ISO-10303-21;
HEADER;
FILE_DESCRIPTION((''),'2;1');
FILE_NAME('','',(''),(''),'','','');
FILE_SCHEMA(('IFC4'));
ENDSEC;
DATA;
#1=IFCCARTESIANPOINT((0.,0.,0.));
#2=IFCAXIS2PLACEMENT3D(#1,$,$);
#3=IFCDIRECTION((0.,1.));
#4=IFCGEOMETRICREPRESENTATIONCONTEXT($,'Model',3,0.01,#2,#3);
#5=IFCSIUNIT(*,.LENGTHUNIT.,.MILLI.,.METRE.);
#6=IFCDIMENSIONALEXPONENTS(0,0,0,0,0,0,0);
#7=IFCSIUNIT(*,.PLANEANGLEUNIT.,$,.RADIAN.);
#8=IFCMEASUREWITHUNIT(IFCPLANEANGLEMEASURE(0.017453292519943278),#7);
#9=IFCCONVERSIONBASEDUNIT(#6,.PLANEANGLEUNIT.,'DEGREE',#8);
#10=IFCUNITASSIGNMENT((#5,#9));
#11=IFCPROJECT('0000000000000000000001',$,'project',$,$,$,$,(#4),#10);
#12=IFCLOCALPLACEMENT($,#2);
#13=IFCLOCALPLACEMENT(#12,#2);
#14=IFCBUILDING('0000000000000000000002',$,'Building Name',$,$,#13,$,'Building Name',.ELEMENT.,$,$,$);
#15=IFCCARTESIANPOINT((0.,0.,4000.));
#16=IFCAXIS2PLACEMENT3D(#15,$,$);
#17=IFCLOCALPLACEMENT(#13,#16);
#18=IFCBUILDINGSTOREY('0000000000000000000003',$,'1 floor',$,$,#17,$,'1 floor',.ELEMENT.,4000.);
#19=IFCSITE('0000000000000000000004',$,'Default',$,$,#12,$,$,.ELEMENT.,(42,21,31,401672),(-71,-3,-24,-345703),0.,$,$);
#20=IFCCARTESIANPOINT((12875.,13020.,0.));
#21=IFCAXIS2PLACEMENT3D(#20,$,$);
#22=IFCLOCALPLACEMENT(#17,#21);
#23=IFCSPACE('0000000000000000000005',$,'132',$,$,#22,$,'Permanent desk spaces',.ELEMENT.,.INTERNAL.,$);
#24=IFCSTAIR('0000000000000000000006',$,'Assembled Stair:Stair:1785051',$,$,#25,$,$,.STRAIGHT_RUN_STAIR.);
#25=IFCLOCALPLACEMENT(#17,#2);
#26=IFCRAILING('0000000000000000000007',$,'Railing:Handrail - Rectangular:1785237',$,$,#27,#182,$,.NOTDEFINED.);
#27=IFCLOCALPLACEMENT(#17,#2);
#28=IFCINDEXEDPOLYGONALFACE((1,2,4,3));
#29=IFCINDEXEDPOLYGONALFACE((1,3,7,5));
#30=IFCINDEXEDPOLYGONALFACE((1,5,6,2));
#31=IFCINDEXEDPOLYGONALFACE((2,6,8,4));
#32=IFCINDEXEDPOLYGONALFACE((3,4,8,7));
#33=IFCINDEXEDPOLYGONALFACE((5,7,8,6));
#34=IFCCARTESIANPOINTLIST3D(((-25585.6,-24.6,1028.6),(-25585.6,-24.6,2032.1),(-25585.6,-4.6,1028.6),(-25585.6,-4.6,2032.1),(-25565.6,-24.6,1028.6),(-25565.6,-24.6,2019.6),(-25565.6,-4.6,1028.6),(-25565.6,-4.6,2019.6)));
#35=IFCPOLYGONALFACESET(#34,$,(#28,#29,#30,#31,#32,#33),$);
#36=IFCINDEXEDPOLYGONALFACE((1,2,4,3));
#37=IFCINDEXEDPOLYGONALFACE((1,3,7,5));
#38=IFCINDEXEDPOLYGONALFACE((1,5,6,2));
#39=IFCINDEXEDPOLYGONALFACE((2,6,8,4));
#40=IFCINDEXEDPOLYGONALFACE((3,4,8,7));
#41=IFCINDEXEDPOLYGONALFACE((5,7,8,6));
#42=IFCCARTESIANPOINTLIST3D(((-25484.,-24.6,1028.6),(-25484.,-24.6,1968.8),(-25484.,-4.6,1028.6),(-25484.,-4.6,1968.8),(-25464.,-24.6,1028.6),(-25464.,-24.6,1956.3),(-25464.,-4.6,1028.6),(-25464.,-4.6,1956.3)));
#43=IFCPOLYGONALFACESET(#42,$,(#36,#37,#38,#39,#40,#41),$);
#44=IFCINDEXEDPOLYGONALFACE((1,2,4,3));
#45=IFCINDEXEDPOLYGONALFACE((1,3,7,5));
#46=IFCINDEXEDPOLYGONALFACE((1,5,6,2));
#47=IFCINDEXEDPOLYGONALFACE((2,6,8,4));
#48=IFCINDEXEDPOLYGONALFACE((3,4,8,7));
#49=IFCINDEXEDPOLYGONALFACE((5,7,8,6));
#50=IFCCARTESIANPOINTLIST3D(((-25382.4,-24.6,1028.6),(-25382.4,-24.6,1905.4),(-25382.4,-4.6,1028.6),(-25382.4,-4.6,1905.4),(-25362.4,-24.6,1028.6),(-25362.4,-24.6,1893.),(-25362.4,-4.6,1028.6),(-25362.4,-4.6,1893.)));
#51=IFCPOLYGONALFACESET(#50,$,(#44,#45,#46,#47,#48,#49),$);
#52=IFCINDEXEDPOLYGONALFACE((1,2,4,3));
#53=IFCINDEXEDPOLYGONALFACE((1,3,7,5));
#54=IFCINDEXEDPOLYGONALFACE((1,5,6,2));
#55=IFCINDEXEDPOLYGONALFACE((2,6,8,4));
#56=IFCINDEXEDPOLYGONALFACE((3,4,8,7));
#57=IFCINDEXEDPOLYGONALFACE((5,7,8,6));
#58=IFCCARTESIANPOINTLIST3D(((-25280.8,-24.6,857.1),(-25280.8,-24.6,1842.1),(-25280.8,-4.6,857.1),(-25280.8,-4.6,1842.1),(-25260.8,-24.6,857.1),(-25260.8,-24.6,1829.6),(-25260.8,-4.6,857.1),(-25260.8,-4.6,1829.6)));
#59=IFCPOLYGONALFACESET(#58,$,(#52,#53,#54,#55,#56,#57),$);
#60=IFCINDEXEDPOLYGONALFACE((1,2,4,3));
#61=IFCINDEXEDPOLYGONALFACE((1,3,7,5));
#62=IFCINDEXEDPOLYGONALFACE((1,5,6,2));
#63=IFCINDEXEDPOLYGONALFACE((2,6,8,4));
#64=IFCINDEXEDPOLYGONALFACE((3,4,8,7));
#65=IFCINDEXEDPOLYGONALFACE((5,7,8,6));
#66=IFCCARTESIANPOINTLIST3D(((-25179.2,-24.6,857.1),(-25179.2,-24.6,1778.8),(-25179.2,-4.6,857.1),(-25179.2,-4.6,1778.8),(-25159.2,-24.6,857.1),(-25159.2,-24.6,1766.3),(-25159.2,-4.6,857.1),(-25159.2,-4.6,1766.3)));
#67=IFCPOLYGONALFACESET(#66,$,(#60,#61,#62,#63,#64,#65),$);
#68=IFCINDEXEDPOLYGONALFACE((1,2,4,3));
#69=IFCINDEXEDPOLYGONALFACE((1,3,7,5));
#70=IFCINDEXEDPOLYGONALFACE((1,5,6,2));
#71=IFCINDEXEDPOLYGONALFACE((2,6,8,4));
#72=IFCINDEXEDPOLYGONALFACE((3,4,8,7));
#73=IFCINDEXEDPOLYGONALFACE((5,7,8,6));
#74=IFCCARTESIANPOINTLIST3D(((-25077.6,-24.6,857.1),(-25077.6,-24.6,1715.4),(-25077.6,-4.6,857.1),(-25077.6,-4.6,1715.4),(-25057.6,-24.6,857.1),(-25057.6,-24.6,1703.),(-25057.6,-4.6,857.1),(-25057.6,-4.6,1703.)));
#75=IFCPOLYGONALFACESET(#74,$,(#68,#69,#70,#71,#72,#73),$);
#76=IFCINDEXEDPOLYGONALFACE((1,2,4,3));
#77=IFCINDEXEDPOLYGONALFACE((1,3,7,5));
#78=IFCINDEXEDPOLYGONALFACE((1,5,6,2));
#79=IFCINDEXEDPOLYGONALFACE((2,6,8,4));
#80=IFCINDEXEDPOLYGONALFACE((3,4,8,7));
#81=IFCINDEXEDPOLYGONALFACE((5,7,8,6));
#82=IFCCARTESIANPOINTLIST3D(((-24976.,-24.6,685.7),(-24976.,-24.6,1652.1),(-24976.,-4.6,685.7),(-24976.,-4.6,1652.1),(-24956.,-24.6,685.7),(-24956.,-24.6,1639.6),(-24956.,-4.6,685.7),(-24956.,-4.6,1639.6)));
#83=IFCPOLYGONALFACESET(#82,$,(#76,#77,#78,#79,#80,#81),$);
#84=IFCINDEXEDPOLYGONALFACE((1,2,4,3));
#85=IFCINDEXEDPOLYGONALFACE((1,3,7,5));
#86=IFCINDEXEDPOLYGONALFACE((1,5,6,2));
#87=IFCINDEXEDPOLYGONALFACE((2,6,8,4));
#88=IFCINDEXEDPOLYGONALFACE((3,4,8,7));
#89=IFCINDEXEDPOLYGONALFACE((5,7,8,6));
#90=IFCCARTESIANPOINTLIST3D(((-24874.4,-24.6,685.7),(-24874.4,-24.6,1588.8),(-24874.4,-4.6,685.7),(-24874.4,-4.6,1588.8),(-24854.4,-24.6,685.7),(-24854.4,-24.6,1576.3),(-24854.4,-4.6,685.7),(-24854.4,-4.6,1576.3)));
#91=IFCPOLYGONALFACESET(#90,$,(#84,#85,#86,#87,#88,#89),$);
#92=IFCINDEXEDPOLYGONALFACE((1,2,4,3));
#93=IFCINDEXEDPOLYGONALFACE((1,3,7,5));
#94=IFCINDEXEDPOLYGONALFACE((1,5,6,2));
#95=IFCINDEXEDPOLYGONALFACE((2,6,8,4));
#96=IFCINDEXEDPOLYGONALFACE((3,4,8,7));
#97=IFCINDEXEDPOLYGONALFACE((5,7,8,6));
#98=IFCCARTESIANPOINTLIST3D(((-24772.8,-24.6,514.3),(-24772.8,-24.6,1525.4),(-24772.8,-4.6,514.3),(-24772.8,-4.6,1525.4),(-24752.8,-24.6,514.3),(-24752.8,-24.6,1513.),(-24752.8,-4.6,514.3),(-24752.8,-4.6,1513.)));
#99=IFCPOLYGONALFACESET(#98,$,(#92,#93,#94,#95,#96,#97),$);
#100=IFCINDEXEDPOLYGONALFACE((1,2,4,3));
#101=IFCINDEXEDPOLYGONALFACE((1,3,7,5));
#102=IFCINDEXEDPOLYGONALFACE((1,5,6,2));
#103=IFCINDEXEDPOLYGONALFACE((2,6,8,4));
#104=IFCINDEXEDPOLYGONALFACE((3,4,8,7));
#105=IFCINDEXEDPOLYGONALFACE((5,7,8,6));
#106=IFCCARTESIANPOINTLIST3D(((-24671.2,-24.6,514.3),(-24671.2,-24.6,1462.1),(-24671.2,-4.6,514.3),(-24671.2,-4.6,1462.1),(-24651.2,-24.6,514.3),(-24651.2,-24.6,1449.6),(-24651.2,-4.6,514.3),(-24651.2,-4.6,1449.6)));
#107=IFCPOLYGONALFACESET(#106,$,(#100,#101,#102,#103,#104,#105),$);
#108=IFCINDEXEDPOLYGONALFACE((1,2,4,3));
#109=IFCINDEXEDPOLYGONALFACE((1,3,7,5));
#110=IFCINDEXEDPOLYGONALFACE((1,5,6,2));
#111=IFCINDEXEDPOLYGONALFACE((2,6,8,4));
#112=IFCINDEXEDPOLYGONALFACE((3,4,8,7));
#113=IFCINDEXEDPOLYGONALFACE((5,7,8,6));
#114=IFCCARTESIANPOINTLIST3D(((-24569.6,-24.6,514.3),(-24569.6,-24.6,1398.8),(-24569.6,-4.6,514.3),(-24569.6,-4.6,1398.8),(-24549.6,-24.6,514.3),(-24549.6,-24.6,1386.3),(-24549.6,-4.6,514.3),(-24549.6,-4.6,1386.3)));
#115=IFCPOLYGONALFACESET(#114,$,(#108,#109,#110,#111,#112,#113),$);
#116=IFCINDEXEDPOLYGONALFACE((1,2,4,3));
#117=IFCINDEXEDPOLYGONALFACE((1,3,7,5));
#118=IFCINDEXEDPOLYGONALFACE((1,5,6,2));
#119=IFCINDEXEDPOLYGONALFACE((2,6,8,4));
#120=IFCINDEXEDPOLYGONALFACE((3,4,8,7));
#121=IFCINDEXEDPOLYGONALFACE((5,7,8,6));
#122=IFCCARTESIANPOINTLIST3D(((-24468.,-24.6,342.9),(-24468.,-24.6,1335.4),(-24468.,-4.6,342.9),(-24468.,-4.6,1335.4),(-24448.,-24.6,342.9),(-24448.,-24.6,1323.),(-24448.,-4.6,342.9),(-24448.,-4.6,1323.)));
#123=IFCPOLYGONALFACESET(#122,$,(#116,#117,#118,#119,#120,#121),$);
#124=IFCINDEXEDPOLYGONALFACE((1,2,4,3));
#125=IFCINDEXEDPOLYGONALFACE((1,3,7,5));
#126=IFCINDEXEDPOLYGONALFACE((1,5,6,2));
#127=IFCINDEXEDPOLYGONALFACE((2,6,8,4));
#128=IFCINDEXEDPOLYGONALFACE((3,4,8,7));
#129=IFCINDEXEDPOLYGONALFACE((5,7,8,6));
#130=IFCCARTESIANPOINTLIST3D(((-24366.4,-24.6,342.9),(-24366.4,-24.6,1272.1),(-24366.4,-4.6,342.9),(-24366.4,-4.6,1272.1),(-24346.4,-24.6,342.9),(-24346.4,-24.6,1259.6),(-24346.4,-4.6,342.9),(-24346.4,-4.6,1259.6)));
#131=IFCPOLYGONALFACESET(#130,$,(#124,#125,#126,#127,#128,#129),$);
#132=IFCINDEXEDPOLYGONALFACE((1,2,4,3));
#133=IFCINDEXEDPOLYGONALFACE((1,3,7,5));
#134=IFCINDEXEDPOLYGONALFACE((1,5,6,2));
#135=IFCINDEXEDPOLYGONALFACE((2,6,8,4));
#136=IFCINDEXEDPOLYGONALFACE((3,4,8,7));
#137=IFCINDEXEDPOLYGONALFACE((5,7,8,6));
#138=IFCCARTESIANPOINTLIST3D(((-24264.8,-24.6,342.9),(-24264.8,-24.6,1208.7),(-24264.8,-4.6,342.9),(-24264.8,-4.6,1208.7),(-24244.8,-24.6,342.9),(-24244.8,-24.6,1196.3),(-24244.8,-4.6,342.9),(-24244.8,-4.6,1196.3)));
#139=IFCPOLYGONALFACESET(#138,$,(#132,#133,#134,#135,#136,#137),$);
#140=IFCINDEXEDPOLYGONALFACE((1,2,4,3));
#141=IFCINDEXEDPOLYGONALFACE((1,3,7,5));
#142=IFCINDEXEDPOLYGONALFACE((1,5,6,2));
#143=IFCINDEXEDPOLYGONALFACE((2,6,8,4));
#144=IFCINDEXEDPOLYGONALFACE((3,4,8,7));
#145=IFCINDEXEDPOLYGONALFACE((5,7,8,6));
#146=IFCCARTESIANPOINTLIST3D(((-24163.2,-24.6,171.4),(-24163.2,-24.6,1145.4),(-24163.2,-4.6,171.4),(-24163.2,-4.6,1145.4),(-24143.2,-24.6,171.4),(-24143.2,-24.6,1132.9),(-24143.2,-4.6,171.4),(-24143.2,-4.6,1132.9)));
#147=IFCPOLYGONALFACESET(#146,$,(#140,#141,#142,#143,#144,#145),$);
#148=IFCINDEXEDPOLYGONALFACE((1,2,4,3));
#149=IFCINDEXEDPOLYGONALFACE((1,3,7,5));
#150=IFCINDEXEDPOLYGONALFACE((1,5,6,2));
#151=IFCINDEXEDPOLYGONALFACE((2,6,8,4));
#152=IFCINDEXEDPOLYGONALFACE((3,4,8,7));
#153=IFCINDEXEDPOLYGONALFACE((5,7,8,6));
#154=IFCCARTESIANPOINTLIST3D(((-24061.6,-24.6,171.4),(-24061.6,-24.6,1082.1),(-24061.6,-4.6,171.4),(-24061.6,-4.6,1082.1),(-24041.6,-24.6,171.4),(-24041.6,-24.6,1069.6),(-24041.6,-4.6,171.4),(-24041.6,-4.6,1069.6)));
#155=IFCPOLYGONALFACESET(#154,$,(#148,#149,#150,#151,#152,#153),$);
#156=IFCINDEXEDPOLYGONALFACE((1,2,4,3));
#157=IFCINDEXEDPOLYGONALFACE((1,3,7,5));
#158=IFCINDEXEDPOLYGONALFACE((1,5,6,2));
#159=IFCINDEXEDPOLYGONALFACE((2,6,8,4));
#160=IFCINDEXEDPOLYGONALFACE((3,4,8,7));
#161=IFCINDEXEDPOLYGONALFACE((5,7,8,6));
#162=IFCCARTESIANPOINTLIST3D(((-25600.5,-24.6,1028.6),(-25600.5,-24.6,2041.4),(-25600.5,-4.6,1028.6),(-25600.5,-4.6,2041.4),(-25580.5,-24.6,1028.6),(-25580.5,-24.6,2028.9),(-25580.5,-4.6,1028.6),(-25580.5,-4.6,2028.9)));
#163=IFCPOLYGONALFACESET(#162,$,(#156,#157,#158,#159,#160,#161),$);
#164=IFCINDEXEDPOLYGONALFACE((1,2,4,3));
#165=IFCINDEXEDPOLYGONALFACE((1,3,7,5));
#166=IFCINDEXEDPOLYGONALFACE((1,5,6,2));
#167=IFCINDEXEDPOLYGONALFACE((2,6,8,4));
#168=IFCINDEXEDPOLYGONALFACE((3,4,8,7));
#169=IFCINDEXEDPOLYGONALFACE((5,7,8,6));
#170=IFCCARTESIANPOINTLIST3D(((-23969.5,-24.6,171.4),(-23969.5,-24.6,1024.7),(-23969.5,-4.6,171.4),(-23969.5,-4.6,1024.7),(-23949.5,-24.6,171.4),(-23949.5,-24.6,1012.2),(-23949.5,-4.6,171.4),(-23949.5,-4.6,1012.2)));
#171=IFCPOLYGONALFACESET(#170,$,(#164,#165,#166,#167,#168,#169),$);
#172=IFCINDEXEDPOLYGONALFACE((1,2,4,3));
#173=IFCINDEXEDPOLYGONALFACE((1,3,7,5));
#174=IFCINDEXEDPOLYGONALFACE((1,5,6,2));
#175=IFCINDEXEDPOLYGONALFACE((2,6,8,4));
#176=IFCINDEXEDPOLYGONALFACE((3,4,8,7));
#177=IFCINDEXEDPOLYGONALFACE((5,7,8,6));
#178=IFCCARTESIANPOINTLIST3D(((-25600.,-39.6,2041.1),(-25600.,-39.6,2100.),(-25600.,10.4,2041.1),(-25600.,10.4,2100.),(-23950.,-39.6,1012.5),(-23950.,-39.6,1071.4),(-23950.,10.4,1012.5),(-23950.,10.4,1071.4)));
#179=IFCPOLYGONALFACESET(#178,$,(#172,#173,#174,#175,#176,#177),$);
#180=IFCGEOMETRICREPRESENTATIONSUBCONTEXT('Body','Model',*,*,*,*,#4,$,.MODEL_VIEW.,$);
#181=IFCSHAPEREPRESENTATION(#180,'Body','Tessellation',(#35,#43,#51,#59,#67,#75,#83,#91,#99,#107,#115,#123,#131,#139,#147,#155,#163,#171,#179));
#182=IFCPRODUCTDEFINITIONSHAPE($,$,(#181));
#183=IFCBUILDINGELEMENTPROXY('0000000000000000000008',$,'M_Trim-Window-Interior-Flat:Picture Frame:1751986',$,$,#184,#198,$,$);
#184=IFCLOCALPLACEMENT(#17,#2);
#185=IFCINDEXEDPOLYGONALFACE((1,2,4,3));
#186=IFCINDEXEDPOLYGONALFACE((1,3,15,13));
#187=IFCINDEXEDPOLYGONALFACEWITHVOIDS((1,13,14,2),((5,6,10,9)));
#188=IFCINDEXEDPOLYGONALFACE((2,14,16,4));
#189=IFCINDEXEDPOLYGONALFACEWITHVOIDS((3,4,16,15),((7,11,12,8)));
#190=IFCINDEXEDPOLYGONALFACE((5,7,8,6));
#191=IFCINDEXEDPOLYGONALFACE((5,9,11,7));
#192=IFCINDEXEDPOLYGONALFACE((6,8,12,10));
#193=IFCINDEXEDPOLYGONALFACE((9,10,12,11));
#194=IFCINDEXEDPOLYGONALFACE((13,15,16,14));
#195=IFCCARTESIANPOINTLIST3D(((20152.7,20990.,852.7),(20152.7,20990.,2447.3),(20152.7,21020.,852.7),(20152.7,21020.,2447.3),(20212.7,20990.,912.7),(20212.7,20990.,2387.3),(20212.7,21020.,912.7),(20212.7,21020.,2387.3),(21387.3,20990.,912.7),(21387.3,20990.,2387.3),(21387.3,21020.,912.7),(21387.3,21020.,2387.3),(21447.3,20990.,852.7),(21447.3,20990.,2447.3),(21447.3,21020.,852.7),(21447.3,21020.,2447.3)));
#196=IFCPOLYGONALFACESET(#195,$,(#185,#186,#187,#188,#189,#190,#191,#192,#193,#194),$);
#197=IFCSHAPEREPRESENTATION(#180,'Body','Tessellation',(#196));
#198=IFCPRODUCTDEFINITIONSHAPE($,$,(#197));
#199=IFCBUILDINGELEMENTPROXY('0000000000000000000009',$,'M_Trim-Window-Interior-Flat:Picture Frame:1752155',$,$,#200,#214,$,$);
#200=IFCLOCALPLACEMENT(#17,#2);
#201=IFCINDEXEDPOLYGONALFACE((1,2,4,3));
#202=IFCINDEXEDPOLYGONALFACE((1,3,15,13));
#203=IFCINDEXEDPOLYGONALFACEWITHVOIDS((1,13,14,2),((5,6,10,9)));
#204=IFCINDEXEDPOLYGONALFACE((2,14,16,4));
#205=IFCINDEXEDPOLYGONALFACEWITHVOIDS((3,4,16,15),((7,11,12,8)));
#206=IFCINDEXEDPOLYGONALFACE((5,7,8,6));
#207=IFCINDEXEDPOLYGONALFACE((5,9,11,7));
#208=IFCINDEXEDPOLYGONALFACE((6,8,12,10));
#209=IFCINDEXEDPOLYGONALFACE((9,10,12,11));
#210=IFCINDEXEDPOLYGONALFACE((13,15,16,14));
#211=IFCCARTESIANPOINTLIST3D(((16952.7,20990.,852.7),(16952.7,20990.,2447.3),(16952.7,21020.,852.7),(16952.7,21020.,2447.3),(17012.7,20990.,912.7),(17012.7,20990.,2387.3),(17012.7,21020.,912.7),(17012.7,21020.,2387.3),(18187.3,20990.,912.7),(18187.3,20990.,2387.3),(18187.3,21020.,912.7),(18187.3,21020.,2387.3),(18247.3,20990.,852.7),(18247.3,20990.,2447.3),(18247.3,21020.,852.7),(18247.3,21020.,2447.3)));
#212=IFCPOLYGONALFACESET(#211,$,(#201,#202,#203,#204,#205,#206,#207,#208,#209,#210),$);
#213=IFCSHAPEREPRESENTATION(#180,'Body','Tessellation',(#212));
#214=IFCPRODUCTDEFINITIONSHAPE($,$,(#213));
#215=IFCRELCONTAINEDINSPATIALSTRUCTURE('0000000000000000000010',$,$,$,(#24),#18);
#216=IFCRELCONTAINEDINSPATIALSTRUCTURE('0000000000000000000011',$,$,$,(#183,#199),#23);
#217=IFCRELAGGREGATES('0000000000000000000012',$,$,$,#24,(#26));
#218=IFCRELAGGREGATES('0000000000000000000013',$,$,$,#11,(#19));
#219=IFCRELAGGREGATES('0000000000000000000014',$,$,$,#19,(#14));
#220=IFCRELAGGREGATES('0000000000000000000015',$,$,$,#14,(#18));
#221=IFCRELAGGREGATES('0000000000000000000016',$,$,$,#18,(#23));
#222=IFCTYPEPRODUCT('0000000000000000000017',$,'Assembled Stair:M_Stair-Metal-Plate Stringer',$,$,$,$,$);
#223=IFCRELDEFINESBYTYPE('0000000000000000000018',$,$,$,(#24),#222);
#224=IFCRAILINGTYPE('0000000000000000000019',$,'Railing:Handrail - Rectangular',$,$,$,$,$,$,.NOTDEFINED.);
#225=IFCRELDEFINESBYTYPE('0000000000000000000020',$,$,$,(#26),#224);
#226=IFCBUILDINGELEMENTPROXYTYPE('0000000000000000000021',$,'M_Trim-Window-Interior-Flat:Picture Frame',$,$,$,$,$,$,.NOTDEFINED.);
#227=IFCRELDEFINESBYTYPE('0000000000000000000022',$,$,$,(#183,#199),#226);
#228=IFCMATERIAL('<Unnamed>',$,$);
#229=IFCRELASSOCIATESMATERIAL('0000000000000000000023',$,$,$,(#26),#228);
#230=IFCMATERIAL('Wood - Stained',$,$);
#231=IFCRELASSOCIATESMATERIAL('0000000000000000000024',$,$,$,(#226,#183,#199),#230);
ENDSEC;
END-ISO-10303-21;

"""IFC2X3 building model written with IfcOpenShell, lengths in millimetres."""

from ifc_helpers import new_model, entity, si_unit, converted_unit, direction, frame, origin, place, context, subcontext, project, spatial, polyline, outline, extrude, source, transform, mapped, material, type_object, type_shapes, element, aggregate, save


model = new_model("IFC2X3")

# Units and contexts
model_context = context("Model", 3, precision=0.01, world=origin(), true_north=direction((0.0, 1.0)))
body_context = subcontext(model_context, "Body", "Model", "MODEL_VIEW")
ifc_project = project(units=[si_unit("LENGTHUNIT", "METRE", prefix="MILLI"), converted_unit("PLANEANGLEUNIT", "DEGREE", entity("IfcPlaneAngleMeasure", 0.017453292519943278), si_unit("PLANEANGLEUNIT", "RADIAN"), dimensions=[0, 0, 0, 0, 0, 0, 0])], contexts=[model_context])

# Site, building, storey
site_placement = place(None, origin())
site = spatial("IfcSite", under=ifc_project, at=site_placement, Name="Default", CompositionType="ELEMENT", RefLatitude=(42, 21, 31, 401672), RefLongitude=(-71, -3, -24, -345703), RefElevation=0.0)
building_placement = place(site_placement, origin())
building = spatial("IfcBuilding", under=site, at=building_placement, Name="Building Name", LongName="Building Name", CompositionType="ELEMENT")
storey_placement = place(building_placement, frame((0.0, 0.0, 4000.0)))
storey = spatial("IfcBuildingStorey", under=building, at=storey_placement, Name="1 floor", LongName="1 floor", CompositionType="ELEMENT", Elevation=4000.0)

# Stair, railing
type_product = type_object("IfcTypeProduct", Name="Assembled Stair:M_Stair-Metal-Plate Stringer")
stair_placement = place(storey_placement, origin())
stair = element("IfcStair", 1, at=stair_placement, inside=storey, type_object=type_product, Name="Assembled Stair:Stair:1785051", ShapeType="STRAIGHT_RUN_STAIR")
ifc_material_1 = material(Name="<Unnamed>")
railing_type = type_object("IfcRailingType", Name="Railing:Handrail - Rectangular", PredefinedType="NOTDEFINED")
railing_placement = place(stair_placement, origin())
railing = element("IfcRailing", 2, at=railing_placement, type_object=railing_type, material=ifc_material_1, Name="Railing:Handrail - Rectangular:1785237", PredefinedType="NOTDEFINED", context=body_context, shape_type="SweptSolid", body=[
    extrude(outline(polyline([(-492.4, -10.0), (498.6, -10.0), (498.6, 10.0), (-504.9, 10.0), (-492.4, -10.0)])), frame((-25575.6, -24.6, 1527.2), z_axis=(0.0, 1.0, 0.0), x_axis=(0.0, 0.0, -1.0)), (0.0, 0.0, 1.0), 20.0),
    extrude(outline(polyline([(-460.7, -10.0), (467.0, -10.0), (467.0, 10.0), (-473.2, 10.0), (-460.7, -10.0)])), frame((-25474.0, -24.6, 1495.6), z_axis=(0.0, 1.0, 0.0), x_axis=(0.0, 0.0, -1.0)), (0.0, 0.0, 1.0), 20.0),
    extrude(outline(polyline([(-429.1, -10.0), (435.3, -10.0), (435.3, 10.0), (-441.5, 10.0), (-429.1, -10.0)])), frame((-25372.4, -24.6, 1463.9), z_axis=(0.0, 1.0, 0.0), x_axis=(0.0, 0.0, -1.0)), (0.0, 0.0, 1.0), 20.0),
    extrude(outline(polyline([(-483.1, -10.0), (489.4, -10.0), (489.4, 10.0), (-495.6, 10.0), (-483.1, -10.0)])), frame((-25270.8, -24.6, 1346.5), z_axis=(0.0, 1.0, 0.0), x_axis=(0.0, 0.0, -1.0)), (0.0, 0.0, 1.0), 20.0),
    extrude(outline(polyline([(-451.5, -10.0), (457.7, -10.0), (457.7, 10.0), (-463.9, 10.0), (-451.5, -10.0)])), frame((-25169.2, -24.6, 1314.8), z_axis=(0.0, 1.0, 0.0), x_axis=(0.0, 0.0, -1.0)), (0.0, 0.0, 1.0), 20.0),
    extrude(outline(polyline([(-419.8, -10.0), (426.0, -10.0), (426.0, 10.0), (-432.3, 10.0), (-419.8, -10.0)])), frame((-25067.6, -24.6, 1283.2), z_axis=(0.0, 1.0, 0.0), x_axis=(0.0, 0.0, -1.0)), (0.0, 0.0, 1.0), 20.0),
    extrude(outline(polyline([(-473.8, -10.0), (480.1, -10.0), (480.1, 10.0), (-486.3, 10.0), (-473.8, -10.0)])), frame((-24966.0, -24.6, 1165.8), z_axis=(0.0, 1.0, 0.0), x_axis=(0.0, 0.0, -1.0)), (0.0, 0.0, 1.0), 20.0),
    extrude(outline(polyline([(-442.2, -10.0), (448.4, -10.0), (448.4, 10.0), (-454.6, 10.0), (-442.2, -10.0)])), frame((-24864.4, -24.6, 1134.1), z_axis=(0.0, 1.0, 0.0), x_axis=(0.0, 0.0, -1.0)), (0.0, 0.0, 1.0), 20.0),
    extrude(outline(polyline([(-496.2, -10.0), (502.5, -10.0), (502.5, 10.0), (-508.7, 10.0), (-496.2, -10.0)])), frame((-24762.8, -24.6, 1016.7), z_axis=(0.0, 1.0, 0.0), x_axis=(0.0, 0.0, -1.0)), (0.0, 0.0, 1.0), 20.0),
    extrude(outline(polyline([(-464.6, -10.0), (470.8, -10.0), (470.8, 10.0), (-477.0, 10.0), (-464.6, -10.0)])), frame((-24661.2, -24.6, 985.1), z_axis=(0.0, 1.0, 0.0), x_axis=(0.0, 0.0, -1.0)), (0.0, 0.0, 1.0), 20.0),
    extrude(outline(polyline([(-432.9, -10.0), (439.1, -10.0), (439.1, 10.0), (-445.4, 10.0), (-432.9, -10.0)])), frame((-24559.6, -24.6, 953.4), z_axis=(0.0, 1.0, 0.0), x_axis=(0.0, 0.0, -1.0)), (0.0, 0.0, 1.0), 20.0),
    extrude(outline(polyline([(-486.9, -10.0), (493.2, -10.0), (493.2, 10.0), (-499.4, 10.0), (-486.9, -10.0)])), frame((-24458.0, -24.6, 836.0), z_axis=(0.0, 1.0, 0.0), x_axis=(0.0, 0.0, -1.0)), (0.0, 0.0, 1.0), 20.0),
    extrude(outline(polyline([(-455.3, -10.0), (461.5, -10.0), (461.5, 10.0), (-467.7, 10.0), (-455.3, -10.0)])), frame((-24356.4, -24.6, 804.4), z_axis=(0.0, 1.0, 0.0), x_axis=(0.0, 0.0, -1.0)), (0.0, 0.0, 1.0), 20.0),
    extrude(outline(polyline([(-423.6, -10.0), (429.8, -10.0), (429.8, 10.0), (-436.1, 10.0), (-423.6, -10.0)])), frame((-24254.8, -24.6, 772.7), z_axis=(0.0, 1.0, 0.0), x_axis=(0.0, 0.0, -1.0)), (0.0, 0.0, 1.0), 20.0),
    extrude(outline(polyline([(-477.6, -10.0), (483.9, -10.0), (483.9, 10.0), (-490.1, 10.0), (-477.6, -10.0)])), frame((-24153.2, -24.6, 655.3), z_axis=(0.0, 1.0, 0.0), x_axis=(0.0, 0.0, -1.0)), (0.0, 0.0, 1.0), 20.0),
    extrude(outline(polyline([(-446.0, -10.0), (452.2, -10.0), (452.2, 10.0), (-458.4, 10.0), (-446.0, -10.0)])), frame((-24051.6, -24.6, 623.6), z_axis=(0.0, 1.0, 0.0), x_axis=(0.0, 0.0, -1.0)), (0.0, 0.0, 1.0), 20.0),
    extrude(outline(polyline([(-497.1, -10.0), (503.3, -10.0), (503.3, 10.0), (-509.5, 10.0), (-497.1, -10.0)])), frame((-25590.5, -24.6, 1531.9), z_axis=(0.0, 1.0, 0.0), x_axis=(0.0, 0.0, -1.0)), (0.0, 0.0, 1.0), 20.0),
    extrude(outline(polyline([(-417.3, -10.0), (423.5, -10.0), (423.5, 10.0), (-429.7, 10.0), (-417.3, -10.0)])), frame((-23959.5, -24.6, 594.9), z_axis=(0.0, 1.0, 0.0), x_axis=(0.0, 0.0, -1.0)), (0.0, 0.0, 1.0), 20.0),
    extrude(outline(polyline([(-987.8, -25.0), (956.6, -25.0), (987.8, 25.0), (-956.6, 25.0), (-987.8, -25.0)])), frame((-24775.0, -39.6, 1556.3), z_axis=(0.0, 1.0, 0.0), x_axis=(-0.848617, 0.0, 0.529008)), (0.0, 0.0, 1.0), 50.0),
])
aggregate(stair, [railing])

# Shared definitions
space_1_placement = place(storey_placement, frame((12875.0, 13020.0, 0.0)))
space_1 = spatial("IfcSpace", under=storey, at=space_1_placement, Name="132", LongName="Permanent desk spaces", CompositionType="ELEMENT", InteriorOrExteriorSpace="INTERNAL")

# Building element proxies
ifc_material_2 = material(Name="Wood - Stained")
building_element_proxy_type = type_object("IfcBuildingElementProxyType", Name="M_Trim-Window-Interior-Flat:Picture Frame", PredefinedType="NOTDEFINED", material=ifc_material_2)
shared_shape_1 = source(origin(), body_context, "Body", "SweptSolid", [
    extrude(outline(polyline([(-647.3, -797.3), (647.3, -797.3), (647.3, 797.3), (-647.3, 797.3), (-647.3, -797.3)]), holes=[polyline([(-587.3, -737.3), (-587.3, 737.3), (587.3, 737.3), (587.3, -737.3), (-587.3, -737.3)])]), frame((0.0, -750.0, 0.0), z_axis=(0.0, 0.0, 1.0), x_axis=(-1.0, 0.0, 0.0)), (0.0, 0.0, 1.0), 30.0),
])
type_shapes(building_element_proxy_type, [shared_shape_1])
for number, where, z_axis, x_axis, name in (
    (3, (7925.0, 8000.0, 2400.0), (0.0, -1.0, 0.0), (1.0, 0.0, 0.0), "M_Trim-Window-Interior-Flat:Picture Frame:1751986"),
    (4, (4725.0, 8000.0, 2400.0), (0.0, -1.0, 0.0), (1.0, 0.0, 0.0), "M_Trim-Window-Interior-Flat:Picture Frame:1752155"),
):
    element("IfcBuildingElementProxy", number, at=place(space_1_placement, frame(where, z_axis=z_axis, x_axis=x_axis)), inside=space_1, type_object=building_element_proxy_type, material=ifc_material_2, Name=name, context=body_context, shape_type="MappedRepresentation", body=[
        mapped(shared_shape_1, transform((0.0, 0.0, 0.0), scale=1.0)),
    ])

save(model, "model.ifc")
